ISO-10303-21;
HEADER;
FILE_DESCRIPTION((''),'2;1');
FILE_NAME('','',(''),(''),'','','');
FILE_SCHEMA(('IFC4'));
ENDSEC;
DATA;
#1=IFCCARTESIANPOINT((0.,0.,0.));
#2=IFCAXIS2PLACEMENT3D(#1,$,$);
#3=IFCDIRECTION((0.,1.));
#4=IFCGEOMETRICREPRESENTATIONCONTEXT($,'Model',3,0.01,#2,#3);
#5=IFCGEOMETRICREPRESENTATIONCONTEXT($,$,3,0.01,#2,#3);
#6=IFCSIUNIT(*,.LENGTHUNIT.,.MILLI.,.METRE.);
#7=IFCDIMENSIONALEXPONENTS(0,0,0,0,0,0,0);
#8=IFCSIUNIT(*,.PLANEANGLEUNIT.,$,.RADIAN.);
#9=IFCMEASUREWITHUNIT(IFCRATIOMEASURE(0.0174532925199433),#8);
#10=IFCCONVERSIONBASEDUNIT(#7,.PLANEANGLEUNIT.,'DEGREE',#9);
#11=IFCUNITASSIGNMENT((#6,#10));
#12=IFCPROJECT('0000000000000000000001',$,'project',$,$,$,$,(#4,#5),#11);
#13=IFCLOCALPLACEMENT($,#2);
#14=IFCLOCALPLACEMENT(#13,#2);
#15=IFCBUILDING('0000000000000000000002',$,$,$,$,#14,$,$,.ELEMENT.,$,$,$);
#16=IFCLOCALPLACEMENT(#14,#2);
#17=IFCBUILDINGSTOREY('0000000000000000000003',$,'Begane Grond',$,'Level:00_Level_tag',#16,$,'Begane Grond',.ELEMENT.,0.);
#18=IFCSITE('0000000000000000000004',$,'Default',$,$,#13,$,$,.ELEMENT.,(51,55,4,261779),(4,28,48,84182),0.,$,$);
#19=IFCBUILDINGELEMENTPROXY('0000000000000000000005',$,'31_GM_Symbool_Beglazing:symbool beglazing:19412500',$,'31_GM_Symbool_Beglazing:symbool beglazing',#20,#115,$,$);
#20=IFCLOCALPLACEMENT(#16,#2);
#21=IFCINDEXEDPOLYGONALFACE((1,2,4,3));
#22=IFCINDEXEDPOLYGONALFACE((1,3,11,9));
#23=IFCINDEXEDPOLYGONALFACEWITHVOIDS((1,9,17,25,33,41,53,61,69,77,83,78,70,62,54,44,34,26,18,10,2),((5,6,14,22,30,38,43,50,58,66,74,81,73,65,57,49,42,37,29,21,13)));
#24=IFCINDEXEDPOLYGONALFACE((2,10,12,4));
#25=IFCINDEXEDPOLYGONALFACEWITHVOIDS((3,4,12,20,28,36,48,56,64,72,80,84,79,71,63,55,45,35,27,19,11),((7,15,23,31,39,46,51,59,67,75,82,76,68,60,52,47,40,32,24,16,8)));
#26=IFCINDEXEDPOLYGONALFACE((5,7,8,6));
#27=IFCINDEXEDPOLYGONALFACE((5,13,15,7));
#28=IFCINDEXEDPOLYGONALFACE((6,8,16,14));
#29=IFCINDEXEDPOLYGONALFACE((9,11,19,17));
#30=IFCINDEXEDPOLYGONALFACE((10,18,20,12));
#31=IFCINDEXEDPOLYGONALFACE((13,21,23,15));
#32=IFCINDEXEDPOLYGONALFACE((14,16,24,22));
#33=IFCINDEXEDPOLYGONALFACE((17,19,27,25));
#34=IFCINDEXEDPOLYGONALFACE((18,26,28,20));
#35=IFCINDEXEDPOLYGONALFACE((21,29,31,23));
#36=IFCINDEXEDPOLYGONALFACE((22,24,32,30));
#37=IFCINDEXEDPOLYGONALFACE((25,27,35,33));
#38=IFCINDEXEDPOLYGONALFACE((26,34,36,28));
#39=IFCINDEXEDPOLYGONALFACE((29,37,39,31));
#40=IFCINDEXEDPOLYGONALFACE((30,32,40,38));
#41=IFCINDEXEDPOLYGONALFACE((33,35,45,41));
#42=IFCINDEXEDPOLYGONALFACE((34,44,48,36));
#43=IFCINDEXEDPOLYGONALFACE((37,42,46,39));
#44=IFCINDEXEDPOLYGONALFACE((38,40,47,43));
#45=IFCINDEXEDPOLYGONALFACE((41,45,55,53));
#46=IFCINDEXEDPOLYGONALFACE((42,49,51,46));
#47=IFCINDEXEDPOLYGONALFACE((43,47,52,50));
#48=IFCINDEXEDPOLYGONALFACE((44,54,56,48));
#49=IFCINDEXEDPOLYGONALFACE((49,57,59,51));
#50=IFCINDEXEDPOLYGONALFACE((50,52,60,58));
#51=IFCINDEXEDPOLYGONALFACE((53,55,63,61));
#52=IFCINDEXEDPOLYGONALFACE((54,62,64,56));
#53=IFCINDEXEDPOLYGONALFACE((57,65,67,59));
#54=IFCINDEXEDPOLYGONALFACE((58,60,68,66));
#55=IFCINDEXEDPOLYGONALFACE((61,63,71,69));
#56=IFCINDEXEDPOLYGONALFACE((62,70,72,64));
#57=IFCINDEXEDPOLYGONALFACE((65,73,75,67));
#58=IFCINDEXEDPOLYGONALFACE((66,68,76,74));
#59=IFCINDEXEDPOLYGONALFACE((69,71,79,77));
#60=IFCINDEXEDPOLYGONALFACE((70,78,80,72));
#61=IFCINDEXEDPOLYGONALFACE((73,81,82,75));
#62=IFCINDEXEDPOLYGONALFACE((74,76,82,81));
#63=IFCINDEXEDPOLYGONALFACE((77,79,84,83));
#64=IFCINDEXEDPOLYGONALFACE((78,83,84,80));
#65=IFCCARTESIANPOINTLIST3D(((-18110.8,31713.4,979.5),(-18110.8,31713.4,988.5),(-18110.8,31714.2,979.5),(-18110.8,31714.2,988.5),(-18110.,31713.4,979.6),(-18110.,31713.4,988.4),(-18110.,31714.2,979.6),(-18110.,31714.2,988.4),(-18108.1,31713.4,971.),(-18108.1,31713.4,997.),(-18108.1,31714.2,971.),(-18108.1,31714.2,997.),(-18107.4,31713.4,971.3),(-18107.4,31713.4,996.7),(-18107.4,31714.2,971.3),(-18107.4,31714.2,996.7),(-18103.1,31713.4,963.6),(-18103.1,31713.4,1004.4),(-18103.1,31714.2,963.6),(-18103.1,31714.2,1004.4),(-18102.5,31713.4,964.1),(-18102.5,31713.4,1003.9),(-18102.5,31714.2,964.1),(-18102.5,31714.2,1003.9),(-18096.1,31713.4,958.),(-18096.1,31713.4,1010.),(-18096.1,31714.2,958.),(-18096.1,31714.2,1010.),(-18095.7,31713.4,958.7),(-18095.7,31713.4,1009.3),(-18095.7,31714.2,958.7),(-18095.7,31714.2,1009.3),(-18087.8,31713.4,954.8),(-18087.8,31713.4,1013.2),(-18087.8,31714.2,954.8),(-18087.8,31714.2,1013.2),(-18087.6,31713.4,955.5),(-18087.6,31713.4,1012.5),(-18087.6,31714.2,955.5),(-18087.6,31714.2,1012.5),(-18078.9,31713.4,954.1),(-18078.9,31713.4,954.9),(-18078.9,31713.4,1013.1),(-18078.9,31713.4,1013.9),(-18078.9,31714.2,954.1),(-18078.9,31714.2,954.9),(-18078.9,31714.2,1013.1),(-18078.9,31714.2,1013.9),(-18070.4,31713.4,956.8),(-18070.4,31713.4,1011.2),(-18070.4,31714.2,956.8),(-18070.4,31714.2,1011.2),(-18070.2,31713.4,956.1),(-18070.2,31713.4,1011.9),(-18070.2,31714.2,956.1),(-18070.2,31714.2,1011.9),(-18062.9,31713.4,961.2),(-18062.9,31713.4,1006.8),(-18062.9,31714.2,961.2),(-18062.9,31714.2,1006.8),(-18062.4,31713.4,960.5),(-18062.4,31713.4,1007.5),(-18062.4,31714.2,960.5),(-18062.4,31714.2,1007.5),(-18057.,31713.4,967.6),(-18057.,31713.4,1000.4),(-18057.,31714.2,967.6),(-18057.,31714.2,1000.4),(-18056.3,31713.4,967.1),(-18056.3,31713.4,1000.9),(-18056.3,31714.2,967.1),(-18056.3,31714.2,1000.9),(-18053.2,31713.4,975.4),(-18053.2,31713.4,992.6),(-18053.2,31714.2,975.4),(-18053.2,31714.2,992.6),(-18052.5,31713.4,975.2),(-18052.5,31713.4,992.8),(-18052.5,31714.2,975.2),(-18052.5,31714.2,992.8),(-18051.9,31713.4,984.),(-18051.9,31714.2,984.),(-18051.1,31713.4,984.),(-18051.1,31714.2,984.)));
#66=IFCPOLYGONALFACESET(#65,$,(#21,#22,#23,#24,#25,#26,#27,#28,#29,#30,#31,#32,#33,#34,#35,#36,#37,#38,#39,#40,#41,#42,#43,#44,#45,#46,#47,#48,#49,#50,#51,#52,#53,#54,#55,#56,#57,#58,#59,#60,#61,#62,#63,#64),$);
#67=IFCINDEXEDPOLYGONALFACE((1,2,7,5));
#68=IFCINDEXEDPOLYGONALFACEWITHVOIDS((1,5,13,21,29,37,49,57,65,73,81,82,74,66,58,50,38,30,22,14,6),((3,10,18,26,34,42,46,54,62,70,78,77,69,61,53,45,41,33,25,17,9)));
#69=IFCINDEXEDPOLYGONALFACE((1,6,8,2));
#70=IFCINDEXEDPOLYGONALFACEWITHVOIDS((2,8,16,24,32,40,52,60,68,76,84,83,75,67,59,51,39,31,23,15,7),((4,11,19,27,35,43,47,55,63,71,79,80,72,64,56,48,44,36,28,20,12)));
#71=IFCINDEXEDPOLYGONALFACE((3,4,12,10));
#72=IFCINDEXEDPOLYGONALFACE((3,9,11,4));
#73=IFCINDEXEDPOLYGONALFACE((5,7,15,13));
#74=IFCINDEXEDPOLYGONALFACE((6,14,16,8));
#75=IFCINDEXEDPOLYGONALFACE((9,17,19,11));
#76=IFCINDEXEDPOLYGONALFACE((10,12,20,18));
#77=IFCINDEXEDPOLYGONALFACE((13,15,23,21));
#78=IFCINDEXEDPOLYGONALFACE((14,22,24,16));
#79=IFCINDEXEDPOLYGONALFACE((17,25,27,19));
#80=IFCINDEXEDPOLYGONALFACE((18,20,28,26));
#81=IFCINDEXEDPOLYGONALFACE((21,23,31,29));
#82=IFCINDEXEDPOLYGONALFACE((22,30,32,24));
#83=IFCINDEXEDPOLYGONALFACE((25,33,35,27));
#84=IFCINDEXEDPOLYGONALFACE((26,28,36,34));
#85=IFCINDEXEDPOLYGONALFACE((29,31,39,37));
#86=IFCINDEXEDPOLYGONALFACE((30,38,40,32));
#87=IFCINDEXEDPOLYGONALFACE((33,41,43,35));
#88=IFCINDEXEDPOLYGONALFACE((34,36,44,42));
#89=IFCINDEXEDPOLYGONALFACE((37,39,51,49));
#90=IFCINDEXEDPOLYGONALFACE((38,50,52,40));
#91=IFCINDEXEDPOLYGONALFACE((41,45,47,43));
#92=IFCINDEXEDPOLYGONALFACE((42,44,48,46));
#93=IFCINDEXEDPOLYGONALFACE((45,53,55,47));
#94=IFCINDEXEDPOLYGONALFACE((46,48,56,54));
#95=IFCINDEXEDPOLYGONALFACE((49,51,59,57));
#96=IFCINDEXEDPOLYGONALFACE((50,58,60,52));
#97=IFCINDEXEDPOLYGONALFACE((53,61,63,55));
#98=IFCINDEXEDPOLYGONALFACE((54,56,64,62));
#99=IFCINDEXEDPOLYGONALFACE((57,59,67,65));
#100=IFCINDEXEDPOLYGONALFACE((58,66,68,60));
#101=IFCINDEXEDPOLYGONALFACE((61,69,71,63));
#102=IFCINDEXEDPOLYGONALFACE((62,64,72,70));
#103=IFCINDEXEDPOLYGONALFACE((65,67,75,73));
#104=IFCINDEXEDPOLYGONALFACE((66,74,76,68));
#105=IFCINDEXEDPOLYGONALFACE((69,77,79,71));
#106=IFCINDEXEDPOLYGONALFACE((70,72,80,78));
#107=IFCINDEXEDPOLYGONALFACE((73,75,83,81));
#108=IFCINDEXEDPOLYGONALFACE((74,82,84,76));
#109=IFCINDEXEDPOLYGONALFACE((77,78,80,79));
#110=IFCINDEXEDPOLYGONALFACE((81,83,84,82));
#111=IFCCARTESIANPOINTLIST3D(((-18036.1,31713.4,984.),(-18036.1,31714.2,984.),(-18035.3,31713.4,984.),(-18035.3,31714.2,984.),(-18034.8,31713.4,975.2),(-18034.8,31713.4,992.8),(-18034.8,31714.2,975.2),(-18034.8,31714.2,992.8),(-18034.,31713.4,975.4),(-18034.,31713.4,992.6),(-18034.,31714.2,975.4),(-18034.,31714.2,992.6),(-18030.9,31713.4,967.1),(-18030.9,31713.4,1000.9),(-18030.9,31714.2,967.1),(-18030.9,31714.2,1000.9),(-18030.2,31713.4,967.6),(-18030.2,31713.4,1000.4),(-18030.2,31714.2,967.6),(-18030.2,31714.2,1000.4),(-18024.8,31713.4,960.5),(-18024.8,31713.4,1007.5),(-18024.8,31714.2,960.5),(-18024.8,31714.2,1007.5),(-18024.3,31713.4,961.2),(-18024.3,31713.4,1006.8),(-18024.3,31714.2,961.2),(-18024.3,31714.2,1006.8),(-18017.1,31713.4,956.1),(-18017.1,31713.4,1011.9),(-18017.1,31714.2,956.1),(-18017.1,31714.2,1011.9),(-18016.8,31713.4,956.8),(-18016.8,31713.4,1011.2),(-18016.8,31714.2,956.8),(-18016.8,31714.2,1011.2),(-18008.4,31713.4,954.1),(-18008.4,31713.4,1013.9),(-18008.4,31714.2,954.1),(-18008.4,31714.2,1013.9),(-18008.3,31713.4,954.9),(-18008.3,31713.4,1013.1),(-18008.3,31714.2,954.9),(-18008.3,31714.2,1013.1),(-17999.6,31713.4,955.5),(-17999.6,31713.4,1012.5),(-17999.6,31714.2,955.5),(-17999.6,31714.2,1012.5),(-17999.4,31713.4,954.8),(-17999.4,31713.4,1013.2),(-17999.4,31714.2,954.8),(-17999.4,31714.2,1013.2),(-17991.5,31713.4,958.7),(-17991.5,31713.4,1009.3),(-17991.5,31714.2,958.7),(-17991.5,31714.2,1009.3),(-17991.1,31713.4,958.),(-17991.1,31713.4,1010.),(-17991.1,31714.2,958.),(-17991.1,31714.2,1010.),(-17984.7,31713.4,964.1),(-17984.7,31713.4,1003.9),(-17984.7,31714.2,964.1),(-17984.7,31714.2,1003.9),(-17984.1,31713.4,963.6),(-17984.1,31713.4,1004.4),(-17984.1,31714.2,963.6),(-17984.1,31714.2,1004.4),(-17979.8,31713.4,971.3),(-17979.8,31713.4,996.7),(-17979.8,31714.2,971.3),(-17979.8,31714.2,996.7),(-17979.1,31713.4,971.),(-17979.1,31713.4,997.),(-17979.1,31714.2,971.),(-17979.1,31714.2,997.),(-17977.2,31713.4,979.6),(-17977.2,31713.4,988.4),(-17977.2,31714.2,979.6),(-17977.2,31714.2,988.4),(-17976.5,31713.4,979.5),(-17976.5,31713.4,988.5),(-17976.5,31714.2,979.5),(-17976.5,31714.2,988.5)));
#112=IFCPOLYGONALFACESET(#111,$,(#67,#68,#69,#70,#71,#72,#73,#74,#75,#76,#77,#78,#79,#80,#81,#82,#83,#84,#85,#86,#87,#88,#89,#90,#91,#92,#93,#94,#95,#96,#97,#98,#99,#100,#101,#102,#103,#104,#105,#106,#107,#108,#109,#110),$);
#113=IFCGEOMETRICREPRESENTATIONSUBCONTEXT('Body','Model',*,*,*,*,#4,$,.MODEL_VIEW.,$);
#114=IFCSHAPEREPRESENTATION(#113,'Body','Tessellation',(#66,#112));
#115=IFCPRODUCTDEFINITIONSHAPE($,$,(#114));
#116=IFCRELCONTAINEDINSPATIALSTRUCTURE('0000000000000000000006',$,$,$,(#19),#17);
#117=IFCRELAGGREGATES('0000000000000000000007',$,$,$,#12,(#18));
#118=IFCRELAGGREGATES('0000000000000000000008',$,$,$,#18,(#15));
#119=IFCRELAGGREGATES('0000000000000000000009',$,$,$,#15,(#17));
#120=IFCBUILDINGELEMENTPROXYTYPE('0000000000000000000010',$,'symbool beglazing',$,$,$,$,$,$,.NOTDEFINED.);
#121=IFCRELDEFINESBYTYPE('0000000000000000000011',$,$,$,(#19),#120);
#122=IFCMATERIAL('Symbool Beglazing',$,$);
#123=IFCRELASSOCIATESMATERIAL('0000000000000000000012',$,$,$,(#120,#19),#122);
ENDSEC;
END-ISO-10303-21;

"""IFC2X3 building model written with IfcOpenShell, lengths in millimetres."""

from ifc_helpers import new_model, entity, si_unit, converted_unit, direction, frame, frame_2d, origin, place, context, subcontext, project, spatial, hollow_circle, extrude, source, transform, mapped, material, type_object, type_shapes, element, save


model = new_model("IFC2X3")

# Units and contexts
model_context = context("Model", 3, precision=0.01, world=origin(), true_north=direction((0.0, 1.0)))
context_of_model = context(None, 3, precision=0.01, world=origin(), true_north=direction((0.0, 1.0)))
body_context = subcontext(model_context, "Body", "Model", "MODEL_VIEW")
ifc_project = project(units=[si_unit("LENGTHUNIT", "METRE", prefix="MILLI"), converted_unit("PLANEANGLEUNIT", "DEGREE", entity("IfcRatioMeasure", 0.0174532925199433), si_unit("PLANEANGLEUNIT", "RADIAN"), dimensions=[0, 0, 0, 0, 0, 0, 0])], contexts=[model_context, context_of_model])

# Site, building, storey
site_placement = place(None, origin())
site = spatial("IfcSite", under=ifc_project, at=site_placement, Name="Default", CompositionType="ELEMENT", RefLatitude=(51, 55, 4, 261779), RefLongitude=(4, 28, 48, 84182), RefElevation=0.0)
building_placement = place(site_placement, origin())
building = spatial("IfcBuilding", under=site, at=building_placement, CompositionType="ELEMENT")
storey_placement = place(building_placement, origin())
storey = spatial("IfcBuildingStorey", under=building, at=storey_placement, Name="Begane Grond", ObjectType="Level:00_Level_tag", LongName="Begane Grond", CompositionType="ELEMENT", Elevation=0.0)

# Building element proxy
ifc_material_1 = material(Name="Symbool Beglazing")
building_element_proxy_type_1 = type_object("IfcBuildingElementProxyType", Name="symbool beglazing", PredefinedType="NOTDEFINED", material=ifc_material_1)
shared_shape_1 = source(origin(), body_context, "Body", "SweptSolid", [
    extrude(hollow_circle(Radius=30.0, WallThickness=0.8, at=frame_2d((0.0, 0.0), x_axis=(1.0, 0.0))), frame((37.5, 0.0, 0.0), z_axis=(0.0, 0.0, 1.0), x_axis=(-1.0, 0.0, 0.0)), (0.0, 0.0, 1.0), 0.8),
    extrude(hollow_circle(Radius=30.0, WallThickness=0.8, at=frame_2d((0.0, 0.0), x_axis=(1.0, 0.0))), frame((-37.5, 0.0, 0.0)), (0.0, 0.0, 1.0), 0.8),
])
type_shapes(building_element_proxy_type_1, [shared_shape_1])
for number, where, z_axis, x_axis, name in (
    (1, (-18043.6, 31713.4, 984.0), (0.0, 1.0, 0.0), (-1.0, 0.0, 0.0), "31_GM_Symbool_Beglazing:symbool beglazing:19412500"),
):
    element("IfcBuildingElementProxy", number, at=place(storey_placement, frame(where, z_axis=z_axis, x_axis=x_axis)), inside=storey, type_object=building_element_proxy_type_1, material=ifc_material_1, Name=name, ObjectType="31_GM_Symbool_Beglazing:symbool beglazing", context=body_context, shape_type="MappedRepresentation", body=[
        mapped(shared_shape_1, transform((0.0, 0.0, 0.0), scale=1.0)),
    ])

save(model, "model.ifc")
